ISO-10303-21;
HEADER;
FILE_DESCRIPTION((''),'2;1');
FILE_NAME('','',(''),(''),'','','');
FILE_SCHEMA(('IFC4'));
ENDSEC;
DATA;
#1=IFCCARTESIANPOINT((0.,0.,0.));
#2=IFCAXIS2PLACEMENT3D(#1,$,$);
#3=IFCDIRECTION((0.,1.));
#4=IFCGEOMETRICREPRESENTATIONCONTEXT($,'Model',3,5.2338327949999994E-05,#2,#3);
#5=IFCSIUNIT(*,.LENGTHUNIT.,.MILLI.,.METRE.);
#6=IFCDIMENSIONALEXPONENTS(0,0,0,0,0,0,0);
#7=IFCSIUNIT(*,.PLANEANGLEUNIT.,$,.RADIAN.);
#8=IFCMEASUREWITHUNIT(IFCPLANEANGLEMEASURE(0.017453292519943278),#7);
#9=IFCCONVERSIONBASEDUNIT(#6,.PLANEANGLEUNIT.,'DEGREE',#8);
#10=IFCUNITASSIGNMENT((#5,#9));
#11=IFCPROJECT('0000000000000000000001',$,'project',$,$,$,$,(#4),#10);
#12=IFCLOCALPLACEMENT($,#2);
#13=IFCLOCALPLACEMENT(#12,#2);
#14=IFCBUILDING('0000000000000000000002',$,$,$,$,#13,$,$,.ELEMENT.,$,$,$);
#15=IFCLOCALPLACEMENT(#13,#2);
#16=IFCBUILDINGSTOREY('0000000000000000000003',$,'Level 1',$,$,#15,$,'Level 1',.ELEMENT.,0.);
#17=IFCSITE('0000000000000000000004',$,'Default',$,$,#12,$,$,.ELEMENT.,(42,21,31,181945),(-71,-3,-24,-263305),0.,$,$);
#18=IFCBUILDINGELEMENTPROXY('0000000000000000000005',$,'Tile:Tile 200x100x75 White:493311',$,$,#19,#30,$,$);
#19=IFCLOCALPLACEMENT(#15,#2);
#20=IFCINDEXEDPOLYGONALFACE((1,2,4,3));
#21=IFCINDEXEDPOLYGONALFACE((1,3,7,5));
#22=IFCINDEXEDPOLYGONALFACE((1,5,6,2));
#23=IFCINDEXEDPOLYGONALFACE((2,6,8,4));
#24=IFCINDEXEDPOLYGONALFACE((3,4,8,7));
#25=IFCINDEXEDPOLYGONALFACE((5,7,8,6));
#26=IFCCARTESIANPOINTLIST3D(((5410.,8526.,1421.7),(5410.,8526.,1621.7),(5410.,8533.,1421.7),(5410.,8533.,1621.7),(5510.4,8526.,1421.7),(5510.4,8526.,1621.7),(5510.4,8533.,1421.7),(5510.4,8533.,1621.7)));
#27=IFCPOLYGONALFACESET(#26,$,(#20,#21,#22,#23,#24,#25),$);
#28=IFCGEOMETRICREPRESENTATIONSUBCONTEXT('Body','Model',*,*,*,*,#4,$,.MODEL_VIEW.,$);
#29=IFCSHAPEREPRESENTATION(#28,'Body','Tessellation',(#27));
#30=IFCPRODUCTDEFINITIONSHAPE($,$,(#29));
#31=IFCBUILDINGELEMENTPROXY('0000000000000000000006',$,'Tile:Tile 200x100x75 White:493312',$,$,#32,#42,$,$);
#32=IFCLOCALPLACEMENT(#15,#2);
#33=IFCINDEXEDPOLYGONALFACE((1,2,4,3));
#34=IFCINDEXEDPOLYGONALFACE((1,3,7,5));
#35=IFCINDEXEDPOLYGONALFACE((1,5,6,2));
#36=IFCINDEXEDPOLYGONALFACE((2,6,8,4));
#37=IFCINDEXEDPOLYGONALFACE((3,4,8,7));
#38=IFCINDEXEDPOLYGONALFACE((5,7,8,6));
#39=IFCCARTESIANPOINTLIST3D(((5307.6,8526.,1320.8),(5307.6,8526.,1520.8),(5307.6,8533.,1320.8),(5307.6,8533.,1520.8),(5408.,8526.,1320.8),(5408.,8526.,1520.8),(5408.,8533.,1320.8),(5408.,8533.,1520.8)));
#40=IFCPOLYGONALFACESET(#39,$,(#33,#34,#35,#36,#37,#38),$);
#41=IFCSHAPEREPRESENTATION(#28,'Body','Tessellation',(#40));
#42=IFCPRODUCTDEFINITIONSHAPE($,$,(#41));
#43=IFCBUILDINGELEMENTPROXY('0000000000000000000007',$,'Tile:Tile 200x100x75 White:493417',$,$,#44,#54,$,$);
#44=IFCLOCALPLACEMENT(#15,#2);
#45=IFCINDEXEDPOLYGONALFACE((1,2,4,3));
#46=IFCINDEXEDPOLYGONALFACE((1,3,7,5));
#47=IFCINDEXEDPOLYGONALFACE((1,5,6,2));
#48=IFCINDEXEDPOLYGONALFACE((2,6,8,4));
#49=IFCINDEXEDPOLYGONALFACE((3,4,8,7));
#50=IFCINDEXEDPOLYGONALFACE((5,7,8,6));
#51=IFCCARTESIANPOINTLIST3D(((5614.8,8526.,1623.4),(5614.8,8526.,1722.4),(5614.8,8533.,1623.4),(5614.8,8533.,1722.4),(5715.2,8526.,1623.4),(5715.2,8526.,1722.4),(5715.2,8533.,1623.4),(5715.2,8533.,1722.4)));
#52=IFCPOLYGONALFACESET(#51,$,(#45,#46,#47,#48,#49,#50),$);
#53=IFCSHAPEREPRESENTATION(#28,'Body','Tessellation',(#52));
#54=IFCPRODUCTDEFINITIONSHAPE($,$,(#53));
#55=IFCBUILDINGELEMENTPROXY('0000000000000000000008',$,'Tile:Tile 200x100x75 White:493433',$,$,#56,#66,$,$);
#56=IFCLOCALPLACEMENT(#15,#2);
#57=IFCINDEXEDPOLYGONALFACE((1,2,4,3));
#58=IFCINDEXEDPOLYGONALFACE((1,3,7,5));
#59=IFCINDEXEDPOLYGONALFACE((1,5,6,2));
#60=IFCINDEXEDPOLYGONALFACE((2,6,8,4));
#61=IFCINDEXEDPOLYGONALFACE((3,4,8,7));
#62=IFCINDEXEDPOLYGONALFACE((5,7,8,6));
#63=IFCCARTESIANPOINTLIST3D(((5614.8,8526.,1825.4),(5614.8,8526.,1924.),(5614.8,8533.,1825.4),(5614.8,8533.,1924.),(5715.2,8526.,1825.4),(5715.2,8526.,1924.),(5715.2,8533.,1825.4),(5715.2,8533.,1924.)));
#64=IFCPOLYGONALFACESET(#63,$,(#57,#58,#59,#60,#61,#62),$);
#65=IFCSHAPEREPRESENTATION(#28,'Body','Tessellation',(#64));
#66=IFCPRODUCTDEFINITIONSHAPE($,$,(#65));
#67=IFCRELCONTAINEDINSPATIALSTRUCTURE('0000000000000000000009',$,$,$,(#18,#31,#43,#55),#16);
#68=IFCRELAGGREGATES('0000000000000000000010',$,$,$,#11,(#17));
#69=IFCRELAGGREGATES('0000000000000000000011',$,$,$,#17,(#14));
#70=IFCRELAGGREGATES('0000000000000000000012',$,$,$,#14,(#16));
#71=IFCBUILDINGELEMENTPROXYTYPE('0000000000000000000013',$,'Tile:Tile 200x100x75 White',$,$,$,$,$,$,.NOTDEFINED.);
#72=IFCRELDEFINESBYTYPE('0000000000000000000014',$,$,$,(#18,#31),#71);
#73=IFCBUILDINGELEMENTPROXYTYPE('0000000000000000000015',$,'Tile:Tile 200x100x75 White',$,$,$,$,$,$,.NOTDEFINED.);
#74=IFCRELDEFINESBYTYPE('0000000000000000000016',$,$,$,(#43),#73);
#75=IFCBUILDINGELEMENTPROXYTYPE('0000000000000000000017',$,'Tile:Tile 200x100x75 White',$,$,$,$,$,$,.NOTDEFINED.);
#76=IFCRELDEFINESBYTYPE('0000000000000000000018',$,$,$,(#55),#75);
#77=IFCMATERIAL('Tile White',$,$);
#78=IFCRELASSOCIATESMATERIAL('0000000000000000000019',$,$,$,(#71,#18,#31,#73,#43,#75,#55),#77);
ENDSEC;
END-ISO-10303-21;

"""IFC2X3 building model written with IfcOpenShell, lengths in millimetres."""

from ifc_helpers import new_model, entity, si_unit, converted_unit, direction, frame, frame_2d, origin, origin_2d_with_axis, place, context, subcontext, project, spatial, rectangle, extrude, source, transform, mapped, material, type_object, type_shapes, element, save


model = new_model("IFC2X3")

# Units and contexts
model_context = context("Model", 3, precision=5.2338327949999994e-05, world=origin(), true_north=direction((0.0, 1.0)))
body_context = subcontext(model_context, "Body", "Model", "MODEL_VIEW")
ifc_project = project(units=[si_unit("LENGTHUNIT", "METRE", prefix="MILLI"), converted_unit("PLANEANGLEUNIT", "DEGREE", entity("IfcPlaneAngleMeasure", 0.017453292519943278), si_unit("PLANEANGLEUNIT", "RADIAN"), dimensions=[0, 0, 0, 0, 0, 0, 0])], contexts=[model_context])

# Site, building, storey
site_placement = place(None, origin())
site = spatial("IfcSite", under=ifc_project, at=site_placement, Name="Default", CompositionType="ELEMENT", RefLatitude=(42, 21, 31, 181945), RefLongitude=(-71, -3, -24, -263305), RefElevation=0.0)
building_placement = place(site_placement, origin())
building = spatial("IfcBuilding", under=site, at=building_placement, CompositionType="ELEMENT")
storey_placement = place(building_placement, origin())
storey = spatial("IfcBuildingStorey", under=building, at=storey_placement, Name="Level 1", LongName="Level 1", CompositionType="ELEMENT", Elevation=0.0)

# Building element proxies
ifc_material_1 = material(Name="Tile White")
building_element_proxy_type_1 = type_object("IfcBuildingElementProxyType", Name="Tile:Tile 200x100x75 White", PredefinedType="NOTDEFINED", material=ifc_material_1)
shared_shape_1 = source(origin(), body_context, "Body", "SweptSolid", [
    extrude(rectangle(XDim=200.0, YDim=100.4, at=frame_2d((0.0, 0.0), x_axis=(1.0, 0.0))), frame((-50.2, -100.0, 0.0), z_axis=(0.0, 0.0, 1.0), x_axis=(0.0, -1.0, 0.0)), (0.0, 0.0, 1.0), 7.0),
])
type_shapes(building_element_proxy_type_1, [shared_shape_1])
for number, where, z_axis, x_axis, name in (
    (1, (5510.4, 8533.0, 1621.7), (0.0, -1.0, 0.0), (1.0, 0.0, 0.0), "Tile:Tile 200x100x75 White:493311"),
    (2, (5408.0, 8533.0, 1520.8), (0.0, -1.0, 0.0), (1.0, 0.0, 0.0), "Tile:Tile 200x100x75 White:493312"),
):
    element("IfcBuildingElementProxy", number, at=place(storey_placement, frame(where, z_axis=z_axis, x_axis=x_axis)), inside=storey, type_object=building_element_proxy_type_1, material=ifc_material_1, Name=name, context=body_context, shape_type="MappedRepresentation", body=[
        mapped(shared_shape_1, transform((0.0, 0.0, 0.0), scale=1.0)),
    ])
building_element_proxy_type_2 = type_object("IfcBuildingElementProxyType", Name="Tile:Tile 200x100x75 White", PredefinedType="NOTDEFINED", material=ifc_material_1)
shared_shape_2 = source(origin(), body_context, "Body", "SweptSolid", [
    extrude(rectangle(XDim=99.0, YDim=100.4, at=origin_2d_with_axis()), frame((-50.2, -49.5, 0.0), z_axis=(0.0, 0.0, 1.0), x_axis=(0.0, -1.0, 0.0)), (0.0, 0.0, 1.0), 7.0),
])
type_shapes(building_element_proxy_type_2, [shared_shape_2])
proxy_1_placement = place(storey_placement, frame((5715.2, 8533.0, 1722.4), z_axis=(0.0, -1.0, 0.0), x_axis=(1.0, 0.0, 0.0)))
element("IfcBuildingElementProxy", 3, at=proxy_1_placement, inside=storey, type_object=building_element_proxy_type_2, material=ifc_material_1, Name="Tile:Tile 200x100x75 White:493417", context=body_context, shape_type="MappedRepresentation", body=[
    mapped(shared_shape_2, transform((0.0, 0.0, 0.0), scale=1.0)),
])
building_element_proxy_type_3 = type_object("IfcBuildingElementProxyType", Name="Tile:Tile 200x100x75 White", PredefinedType="NOTDEFINED", material=ifc_material_1)
shared_shape_3 = source(origin(), body_context, "Body", "SweptSolid", [
    extrude(rectangle(XDim=98.6, YDim=100.4, at=origin_2d_with_axis()), frame((-50.2, -49.3, 0.0), z_axis=(0.0, 0.0, 1.0), x_axis=(0.0, -1.0, 0.0)), (0.0, 0.0, 1.0), 7.0),
])
type_shapes(building_element_proxy_type_3, [shared_shape_3])
proxy_2_placement = place(storey_placement, frame((5715.2, 8533.0, 1924.0), z_axis=(0.0, -1.0, 0.0), x_axis=(1.0, 0.0, 0.0)))
element("IfcBuildingElementProxy", 4, at=proxy_2_placement, inside=storey, type_object=building_element_proxy_type_3, material=ifc_material_1, Name="Tile:Tile 200x100x75 White:493433", context=body_context, shape_type="MappedRepresentation", body=[
    mapped(shared_shape_3, transform((0.0, 0.0, 0.0), scale=1.0)),
])

save(model, "model.ifc")
